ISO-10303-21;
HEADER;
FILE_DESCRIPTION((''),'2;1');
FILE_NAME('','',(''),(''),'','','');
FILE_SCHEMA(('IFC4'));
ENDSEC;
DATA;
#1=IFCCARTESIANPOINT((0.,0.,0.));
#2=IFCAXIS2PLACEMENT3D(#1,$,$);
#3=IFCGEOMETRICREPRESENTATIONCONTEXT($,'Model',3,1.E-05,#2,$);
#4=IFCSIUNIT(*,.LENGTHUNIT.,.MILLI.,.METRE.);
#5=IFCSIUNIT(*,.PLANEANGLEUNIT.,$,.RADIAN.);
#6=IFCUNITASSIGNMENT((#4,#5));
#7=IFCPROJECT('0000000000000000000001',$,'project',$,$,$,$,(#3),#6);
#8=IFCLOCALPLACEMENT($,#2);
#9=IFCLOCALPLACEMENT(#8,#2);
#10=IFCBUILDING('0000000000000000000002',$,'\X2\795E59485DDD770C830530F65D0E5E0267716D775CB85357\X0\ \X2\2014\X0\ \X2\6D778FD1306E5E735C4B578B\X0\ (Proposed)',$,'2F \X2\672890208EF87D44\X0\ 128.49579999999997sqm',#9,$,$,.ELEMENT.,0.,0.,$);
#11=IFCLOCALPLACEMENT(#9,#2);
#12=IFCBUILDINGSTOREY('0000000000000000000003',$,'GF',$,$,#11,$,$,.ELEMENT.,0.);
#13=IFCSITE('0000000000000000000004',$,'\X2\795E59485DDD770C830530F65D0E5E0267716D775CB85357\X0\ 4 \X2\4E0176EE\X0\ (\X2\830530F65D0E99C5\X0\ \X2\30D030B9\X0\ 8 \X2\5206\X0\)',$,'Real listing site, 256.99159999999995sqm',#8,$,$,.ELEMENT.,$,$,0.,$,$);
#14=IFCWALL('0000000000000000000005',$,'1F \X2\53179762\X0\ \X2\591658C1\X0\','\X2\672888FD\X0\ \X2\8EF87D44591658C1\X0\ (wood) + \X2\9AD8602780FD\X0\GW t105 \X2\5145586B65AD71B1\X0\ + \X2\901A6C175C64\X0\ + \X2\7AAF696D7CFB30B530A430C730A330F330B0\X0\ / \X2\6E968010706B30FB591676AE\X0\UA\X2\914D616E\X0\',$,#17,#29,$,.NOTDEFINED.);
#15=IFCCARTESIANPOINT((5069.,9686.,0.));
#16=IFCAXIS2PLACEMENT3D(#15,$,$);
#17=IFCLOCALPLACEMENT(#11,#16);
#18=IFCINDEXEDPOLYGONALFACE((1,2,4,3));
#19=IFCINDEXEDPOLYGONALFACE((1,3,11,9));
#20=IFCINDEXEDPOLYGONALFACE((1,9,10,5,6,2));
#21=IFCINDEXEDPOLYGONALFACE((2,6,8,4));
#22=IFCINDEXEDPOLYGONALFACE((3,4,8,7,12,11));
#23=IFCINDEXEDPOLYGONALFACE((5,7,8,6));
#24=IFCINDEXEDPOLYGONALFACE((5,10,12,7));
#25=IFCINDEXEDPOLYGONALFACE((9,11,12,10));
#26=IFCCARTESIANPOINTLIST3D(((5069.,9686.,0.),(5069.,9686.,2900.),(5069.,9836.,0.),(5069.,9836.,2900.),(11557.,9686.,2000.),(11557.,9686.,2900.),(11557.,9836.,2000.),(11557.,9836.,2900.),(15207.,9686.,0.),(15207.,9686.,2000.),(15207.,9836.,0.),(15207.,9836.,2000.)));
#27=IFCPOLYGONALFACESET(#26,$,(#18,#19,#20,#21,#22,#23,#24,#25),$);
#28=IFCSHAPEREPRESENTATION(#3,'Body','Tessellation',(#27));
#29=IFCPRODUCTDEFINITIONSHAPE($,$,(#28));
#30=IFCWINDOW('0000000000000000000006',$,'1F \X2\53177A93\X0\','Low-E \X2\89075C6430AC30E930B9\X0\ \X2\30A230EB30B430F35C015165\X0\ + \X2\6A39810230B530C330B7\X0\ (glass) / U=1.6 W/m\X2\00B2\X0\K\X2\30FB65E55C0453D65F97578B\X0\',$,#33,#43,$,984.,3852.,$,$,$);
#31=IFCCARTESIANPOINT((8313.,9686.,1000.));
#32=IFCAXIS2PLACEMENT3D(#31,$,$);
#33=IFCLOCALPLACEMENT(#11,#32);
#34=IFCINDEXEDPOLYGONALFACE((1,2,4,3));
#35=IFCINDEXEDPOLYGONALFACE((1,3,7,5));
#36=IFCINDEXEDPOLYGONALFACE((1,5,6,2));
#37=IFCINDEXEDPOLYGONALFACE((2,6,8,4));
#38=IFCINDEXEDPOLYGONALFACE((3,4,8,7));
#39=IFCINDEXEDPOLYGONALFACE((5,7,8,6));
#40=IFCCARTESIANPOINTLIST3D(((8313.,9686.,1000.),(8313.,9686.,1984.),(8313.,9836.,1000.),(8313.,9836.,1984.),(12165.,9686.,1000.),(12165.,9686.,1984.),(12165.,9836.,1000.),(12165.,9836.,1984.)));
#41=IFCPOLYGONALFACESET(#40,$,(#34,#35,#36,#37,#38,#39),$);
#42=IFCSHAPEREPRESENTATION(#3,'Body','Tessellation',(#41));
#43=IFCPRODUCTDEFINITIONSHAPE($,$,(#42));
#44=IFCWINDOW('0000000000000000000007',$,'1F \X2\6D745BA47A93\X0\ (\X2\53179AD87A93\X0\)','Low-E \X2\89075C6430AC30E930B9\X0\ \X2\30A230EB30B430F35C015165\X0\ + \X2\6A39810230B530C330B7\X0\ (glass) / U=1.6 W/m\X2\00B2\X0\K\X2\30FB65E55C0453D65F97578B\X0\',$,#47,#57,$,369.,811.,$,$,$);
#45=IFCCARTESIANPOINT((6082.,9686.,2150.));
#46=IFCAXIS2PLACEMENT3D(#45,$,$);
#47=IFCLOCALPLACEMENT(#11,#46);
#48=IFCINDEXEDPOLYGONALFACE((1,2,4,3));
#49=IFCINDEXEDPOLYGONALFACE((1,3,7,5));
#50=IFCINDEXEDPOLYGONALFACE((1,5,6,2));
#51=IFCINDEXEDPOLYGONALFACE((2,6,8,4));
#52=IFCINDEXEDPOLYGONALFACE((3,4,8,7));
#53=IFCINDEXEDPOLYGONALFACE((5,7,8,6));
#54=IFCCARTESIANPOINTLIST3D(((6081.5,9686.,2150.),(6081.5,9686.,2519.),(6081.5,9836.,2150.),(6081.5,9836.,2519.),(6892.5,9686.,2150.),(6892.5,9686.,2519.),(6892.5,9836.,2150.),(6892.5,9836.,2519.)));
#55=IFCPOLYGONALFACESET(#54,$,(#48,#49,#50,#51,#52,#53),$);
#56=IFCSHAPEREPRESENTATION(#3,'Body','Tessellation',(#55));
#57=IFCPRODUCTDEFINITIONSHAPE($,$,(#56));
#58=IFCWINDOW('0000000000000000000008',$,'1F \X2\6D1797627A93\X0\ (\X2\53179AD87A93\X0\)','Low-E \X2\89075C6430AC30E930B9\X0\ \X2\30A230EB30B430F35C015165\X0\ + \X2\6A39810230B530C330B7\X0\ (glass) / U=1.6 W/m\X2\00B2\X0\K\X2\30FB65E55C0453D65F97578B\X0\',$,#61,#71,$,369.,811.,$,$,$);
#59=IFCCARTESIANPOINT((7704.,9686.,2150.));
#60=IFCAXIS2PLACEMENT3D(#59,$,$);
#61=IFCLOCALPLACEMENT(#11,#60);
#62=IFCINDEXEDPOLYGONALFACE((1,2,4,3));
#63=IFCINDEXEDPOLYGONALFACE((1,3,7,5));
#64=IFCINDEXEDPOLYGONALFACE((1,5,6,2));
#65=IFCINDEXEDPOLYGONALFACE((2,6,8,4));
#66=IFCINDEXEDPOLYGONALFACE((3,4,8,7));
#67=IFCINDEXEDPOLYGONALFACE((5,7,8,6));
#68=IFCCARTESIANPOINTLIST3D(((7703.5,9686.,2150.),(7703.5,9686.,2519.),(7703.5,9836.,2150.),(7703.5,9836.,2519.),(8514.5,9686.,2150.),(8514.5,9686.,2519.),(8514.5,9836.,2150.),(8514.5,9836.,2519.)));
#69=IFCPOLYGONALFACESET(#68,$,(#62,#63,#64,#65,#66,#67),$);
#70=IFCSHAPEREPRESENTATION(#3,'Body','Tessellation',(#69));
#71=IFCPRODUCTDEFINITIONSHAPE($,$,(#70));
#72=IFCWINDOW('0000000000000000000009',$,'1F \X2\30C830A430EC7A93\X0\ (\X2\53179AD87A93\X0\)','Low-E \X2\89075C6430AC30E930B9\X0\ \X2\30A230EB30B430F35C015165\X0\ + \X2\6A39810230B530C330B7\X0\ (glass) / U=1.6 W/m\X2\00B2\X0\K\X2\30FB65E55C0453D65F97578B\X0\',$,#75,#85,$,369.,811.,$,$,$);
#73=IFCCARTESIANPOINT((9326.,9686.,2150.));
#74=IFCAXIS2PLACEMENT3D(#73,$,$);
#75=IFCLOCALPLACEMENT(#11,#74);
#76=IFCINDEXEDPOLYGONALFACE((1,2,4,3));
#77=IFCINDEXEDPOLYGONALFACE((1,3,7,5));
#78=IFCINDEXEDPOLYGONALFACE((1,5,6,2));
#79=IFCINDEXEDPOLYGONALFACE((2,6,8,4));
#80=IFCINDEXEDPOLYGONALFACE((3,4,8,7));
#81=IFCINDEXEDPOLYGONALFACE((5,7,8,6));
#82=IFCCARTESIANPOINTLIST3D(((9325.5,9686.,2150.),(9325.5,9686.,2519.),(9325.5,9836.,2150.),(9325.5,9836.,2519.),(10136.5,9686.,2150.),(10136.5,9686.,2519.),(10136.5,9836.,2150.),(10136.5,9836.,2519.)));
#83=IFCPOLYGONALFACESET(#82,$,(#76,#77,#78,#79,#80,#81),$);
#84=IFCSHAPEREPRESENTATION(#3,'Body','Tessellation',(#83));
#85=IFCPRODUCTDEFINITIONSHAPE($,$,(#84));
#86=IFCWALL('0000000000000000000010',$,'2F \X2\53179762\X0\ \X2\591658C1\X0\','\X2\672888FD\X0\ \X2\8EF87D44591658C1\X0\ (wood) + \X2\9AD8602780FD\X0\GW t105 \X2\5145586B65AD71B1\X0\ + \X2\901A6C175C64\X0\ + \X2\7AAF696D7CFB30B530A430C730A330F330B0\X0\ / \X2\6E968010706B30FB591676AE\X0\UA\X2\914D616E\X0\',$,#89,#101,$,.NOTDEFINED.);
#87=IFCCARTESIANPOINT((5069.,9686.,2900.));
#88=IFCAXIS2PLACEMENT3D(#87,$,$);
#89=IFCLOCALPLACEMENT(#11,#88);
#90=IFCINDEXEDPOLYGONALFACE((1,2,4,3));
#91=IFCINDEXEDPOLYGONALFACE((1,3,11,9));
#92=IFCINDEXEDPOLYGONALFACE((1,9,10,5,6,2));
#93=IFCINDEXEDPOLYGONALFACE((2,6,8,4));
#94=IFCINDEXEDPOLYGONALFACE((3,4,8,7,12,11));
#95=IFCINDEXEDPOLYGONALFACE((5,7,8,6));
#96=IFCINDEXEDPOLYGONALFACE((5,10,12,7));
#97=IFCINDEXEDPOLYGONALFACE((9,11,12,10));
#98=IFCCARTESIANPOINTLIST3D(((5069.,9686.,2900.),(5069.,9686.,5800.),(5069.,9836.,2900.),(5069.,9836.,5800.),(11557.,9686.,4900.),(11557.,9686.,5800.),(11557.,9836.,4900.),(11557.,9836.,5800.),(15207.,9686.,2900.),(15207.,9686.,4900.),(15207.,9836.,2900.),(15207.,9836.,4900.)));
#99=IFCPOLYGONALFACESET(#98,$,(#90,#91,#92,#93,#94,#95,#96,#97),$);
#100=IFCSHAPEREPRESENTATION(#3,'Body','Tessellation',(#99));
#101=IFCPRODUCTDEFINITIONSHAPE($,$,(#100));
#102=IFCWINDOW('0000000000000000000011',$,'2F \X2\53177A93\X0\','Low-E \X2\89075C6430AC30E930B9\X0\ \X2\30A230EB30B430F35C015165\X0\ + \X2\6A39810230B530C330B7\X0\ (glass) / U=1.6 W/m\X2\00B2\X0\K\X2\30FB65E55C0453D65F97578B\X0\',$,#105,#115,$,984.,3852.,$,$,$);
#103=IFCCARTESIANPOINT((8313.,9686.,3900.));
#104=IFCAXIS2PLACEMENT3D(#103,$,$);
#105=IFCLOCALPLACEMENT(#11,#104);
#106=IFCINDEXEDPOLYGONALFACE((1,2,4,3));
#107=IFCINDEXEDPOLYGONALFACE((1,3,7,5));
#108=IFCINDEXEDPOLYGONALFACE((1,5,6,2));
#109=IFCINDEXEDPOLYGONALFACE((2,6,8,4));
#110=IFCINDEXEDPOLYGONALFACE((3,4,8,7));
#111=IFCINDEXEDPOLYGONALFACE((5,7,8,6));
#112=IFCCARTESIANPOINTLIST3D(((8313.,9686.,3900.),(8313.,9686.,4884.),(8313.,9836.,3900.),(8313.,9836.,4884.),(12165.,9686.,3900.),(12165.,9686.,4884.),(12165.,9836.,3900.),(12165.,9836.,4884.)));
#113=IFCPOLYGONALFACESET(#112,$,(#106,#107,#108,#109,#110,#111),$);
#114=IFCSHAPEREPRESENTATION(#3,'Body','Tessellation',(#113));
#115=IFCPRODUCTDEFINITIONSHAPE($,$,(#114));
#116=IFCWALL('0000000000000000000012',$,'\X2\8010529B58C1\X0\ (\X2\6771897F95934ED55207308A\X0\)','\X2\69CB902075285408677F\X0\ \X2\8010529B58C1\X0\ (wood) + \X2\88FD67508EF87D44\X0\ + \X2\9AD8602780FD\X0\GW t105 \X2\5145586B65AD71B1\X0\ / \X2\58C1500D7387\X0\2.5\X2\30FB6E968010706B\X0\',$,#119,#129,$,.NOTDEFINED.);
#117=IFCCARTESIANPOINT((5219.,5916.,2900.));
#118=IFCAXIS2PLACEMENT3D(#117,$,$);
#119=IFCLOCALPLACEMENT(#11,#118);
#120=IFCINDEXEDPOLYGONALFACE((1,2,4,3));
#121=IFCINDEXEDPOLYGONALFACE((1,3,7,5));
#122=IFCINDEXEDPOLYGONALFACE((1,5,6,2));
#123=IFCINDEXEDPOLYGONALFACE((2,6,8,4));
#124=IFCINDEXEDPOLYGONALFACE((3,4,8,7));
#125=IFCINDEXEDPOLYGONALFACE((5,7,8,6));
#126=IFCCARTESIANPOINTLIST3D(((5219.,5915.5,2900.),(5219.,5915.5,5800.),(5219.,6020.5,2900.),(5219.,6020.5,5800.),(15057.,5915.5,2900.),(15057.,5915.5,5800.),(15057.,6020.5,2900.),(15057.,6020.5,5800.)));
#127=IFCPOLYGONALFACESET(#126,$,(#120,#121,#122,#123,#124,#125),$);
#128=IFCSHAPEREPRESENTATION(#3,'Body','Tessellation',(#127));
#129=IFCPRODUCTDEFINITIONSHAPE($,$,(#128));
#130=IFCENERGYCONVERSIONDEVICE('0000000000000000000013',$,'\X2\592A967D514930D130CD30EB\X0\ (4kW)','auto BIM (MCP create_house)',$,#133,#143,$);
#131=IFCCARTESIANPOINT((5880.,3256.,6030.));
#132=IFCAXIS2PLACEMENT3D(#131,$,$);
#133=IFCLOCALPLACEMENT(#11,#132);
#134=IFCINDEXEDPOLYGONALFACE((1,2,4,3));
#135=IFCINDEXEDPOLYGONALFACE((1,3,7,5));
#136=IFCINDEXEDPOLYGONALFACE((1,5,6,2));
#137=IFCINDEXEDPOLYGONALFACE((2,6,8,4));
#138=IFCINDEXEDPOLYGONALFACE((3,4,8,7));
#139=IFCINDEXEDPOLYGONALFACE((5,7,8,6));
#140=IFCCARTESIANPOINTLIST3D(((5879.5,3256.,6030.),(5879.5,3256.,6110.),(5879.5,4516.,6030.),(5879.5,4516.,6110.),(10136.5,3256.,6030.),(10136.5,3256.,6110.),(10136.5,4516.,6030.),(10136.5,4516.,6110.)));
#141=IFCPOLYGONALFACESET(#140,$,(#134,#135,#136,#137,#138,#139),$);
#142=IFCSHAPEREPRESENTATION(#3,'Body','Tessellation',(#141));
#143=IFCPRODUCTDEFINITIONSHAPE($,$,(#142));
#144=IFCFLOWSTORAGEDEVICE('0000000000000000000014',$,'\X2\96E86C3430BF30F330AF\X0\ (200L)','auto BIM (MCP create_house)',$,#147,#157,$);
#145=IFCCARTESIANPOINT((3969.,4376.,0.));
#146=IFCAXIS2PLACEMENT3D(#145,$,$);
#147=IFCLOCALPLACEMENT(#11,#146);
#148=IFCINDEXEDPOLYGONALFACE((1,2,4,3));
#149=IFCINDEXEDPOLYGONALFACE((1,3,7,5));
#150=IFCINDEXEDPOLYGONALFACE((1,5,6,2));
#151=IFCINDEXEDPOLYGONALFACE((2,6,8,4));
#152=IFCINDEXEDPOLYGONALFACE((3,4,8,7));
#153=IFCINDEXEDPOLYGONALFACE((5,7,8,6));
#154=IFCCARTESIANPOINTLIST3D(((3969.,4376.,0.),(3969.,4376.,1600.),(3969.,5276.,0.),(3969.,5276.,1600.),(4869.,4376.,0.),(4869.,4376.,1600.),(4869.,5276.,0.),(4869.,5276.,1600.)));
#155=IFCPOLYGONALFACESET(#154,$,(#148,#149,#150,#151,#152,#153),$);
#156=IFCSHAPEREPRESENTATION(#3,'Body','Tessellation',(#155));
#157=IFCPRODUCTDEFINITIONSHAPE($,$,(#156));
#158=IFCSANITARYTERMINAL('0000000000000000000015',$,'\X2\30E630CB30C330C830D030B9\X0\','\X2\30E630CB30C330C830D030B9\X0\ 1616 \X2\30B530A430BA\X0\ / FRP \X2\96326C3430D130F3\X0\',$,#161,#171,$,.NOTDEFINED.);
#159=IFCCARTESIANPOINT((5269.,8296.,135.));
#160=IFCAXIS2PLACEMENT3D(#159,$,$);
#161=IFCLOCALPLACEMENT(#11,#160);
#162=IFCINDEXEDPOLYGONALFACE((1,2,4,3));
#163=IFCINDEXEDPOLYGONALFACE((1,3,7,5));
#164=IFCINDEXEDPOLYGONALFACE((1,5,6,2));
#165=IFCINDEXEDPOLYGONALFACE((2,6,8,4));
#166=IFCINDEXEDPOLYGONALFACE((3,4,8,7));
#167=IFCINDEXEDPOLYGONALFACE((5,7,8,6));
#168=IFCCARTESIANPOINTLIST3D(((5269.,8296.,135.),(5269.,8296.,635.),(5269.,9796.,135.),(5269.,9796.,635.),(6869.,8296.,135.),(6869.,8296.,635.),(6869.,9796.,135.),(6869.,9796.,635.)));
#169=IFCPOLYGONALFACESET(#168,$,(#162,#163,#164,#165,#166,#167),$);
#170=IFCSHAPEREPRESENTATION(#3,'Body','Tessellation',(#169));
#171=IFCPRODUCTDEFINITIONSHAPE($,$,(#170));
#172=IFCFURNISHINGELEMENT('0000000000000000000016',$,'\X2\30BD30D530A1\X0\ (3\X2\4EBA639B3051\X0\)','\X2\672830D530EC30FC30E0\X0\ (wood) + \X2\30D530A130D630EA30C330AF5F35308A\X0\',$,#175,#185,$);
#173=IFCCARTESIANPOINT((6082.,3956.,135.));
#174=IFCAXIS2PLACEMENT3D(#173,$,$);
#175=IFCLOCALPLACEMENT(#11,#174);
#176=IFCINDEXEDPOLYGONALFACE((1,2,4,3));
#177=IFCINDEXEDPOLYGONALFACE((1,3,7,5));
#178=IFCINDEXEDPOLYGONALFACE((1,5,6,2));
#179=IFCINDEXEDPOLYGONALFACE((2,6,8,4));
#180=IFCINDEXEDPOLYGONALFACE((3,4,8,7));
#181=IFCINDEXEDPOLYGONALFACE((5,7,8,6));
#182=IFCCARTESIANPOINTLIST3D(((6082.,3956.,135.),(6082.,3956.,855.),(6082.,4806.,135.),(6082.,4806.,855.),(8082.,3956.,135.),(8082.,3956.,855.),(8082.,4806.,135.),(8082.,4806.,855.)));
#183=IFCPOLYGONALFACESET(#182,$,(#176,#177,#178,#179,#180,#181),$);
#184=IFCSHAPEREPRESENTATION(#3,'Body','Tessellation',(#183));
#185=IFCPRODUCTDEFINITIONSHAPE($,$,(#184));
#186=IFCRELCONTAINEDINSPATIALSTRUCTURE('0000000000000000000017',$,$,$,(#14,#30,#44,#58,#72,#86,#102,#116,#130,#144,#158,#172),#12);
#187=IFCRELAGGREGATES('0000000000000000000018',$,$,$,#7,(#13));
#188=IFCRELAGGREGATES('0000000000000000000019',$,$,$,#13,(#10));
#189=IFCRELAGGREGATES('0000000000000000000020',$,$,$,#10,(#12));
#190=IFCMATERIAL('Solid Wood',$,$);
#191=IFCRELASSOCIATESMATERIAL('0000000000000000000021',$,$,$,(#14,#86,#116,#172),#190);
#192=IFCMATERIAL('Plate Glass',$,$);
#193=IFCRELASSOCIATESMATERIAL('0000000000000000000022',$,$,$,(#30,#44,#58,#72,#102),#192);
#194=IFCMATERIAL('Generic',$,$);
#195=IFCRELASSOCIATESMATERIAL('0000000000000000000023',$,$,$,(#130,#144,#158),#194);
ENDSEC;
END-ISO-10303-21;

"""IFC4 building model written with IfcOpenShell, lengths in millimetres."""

from ifc_helpers import new_model, si_unit, frame, frame_2d, origin, place, context, project, spatial, rectangle, extrude, material, element, fill, save


model = new_model("IFC4")

# Units and contexts
model_context = context("Model", 3, precision=1e-05, world=origin())
ifc_project = project(units=[si_unit("LENGTHUNIT", "METRE", prefix="MILLI"), si_unit("PLANEANGLEUNIT", "RADIAN")], contexts=[model_context])

# Site, building, storey
site_placement = place(None, origin())
site = spatial("IfcSite", under=ifc_project, at=site_placement, Name="神奈川県茅ヶ崎市東海岸南 4 丁目 (茅ヶ崎駅 バス 8 分)", ObjectType="Real listing site, 256.99159999999995sqm", CompositionType="ELEMENT", RefElevation=0.0)
building_placement = place(site_placement, origin())
building = spatial("IfcBuilding", under=site, at=building_placement, Name="神奈川県茅ヶ崎市東海岸南 — 海近の平屋型 (Proposed)", ObjectType="2F 木造軸組 128.49579999999997sqm", CompositionType="ELEMENT", ElevationOfRefHeight=0.0, ElevationOfTerrain=0.0)
storey_placement = place(building_placement, origin())
storey = spatial("IfcBuildingStorey", under=building, at=storey_placement, Name="GF", CompositionType="ELEMENT", Elevation=0.0)

# Wall, openings, windows
ifc_material_1 = material(Name="Solid Wood")
wall_1_placement = place(storey_placement, frame((5069.0, 9686.0, 0.0)))
wall_1 = element("IfcWall", 1, at=wall_1_placement, inside=storey, material=ifc_material_1, Name="1F 北面 外壁", Description="木製 軸組外壁 (wood) + 高性能GW t105 充填断熱 + 通気層 + 窯業系サイディング / 準耐火・外皮UA配慮", PredefinedType="NOTDEFINED", context=model_context, shape_type="SweptSolid", body=[
    extrude(rectangle(XDim=10138.0, YDim=150.0, at=frame_2d((5069.0, 75.0))), frame((5069.0, 9686.0, 0.0)), (0.0, 0.0, 1.0), 2900.0),
])
opening_1_placement = place(storey_placement, frame((8313.0, 9686.0, 1000.0)))
opening_1 = element("IfcOpeningElement", 2, at=opening_1_placement, cuts=wall_1, PredefinedType="NOTDEFINED", context=model_context, shape_type="SweptSolid", body=[
    extrude(rectangle(XDim=3852.0, YDim=150.0, at=frame_2d((1926.0, 75.0))), frame((8313.0, 9686.0, 1000.0)), (0.0, 0.0, 1.0), 984.0),
])
opening_2_placement = place(storey_placement, frame((6082.0, 9686.0, 2150.0)))
opening_2 = element("IfcOpeningElement", 3, at=opening_2_placement, cuts=wall_1, PredefinedType="NOTDEFINED", context=model_context, shape_type="SweptSolid", body=[
    extrude(rectangle(XDim=811.0, YDim=150.0, at=frame_2d((405.0, 75.0))), frame((6082.0, 9686.0, 2150.0)), (0.0, 0.0, 1.0), 369.0),
])
opening_3_placement = place(storey_placement, frame((7704.0, 9686.0, 2150.0)))
opening_3 = element("IfcOpeningElement", 4, at=opening_3_placement, cuts=wall_1, PredefinedType="NOTDEFINED", context=model_context, shape_type="SweptSolid", body=[
    extrude(rectangle(XDim=811.0, YDim=150.0, at=frame_2d((405.0, 75.0))), frame((7704.0, 9686.0, 2150.0)), (0.0, 0.0, 1.0), 369.0),
])
opening_4_placement = place(storey_placement, frame((9326.0, 9686.0, 2150.0)))
opening_4 = element("IfcOpeningElement", 5, at=opening_4_placement, cuts=wall_1, PredefinedType="NOTDEFINED", context=model_context, shape_type="SweptSolid", body=[
    extrude(rectangle(XDim=811.0, YDim=150.0, at=frame_2d((405.0, 75.0))), frame((9326.0, 9686.0, 2150.0)), (0.0, 0.0, 1.0), 369.0),
])
ifc_material_2 = material(Name="Plate Glass")
window_1_placement = place(storey_placement, frame((8313.0, 9686.0, 1000.0)))
window_1 = element("IfcWindow", 6, at=window_1_placement, inside=storey, material=ifc_material_2, Name="1F 北窓", Description="Low-E 複層ガラス アルゴン封入 + 樹脂サッシ (glass) / U=1.6 W/m²K・日射取得型", OverallHeight=984.0, OverallWidth=3852.0, context=model_context, shape_type="SweptSolid", body=[
    extrude(rectangle(XDim=3852.0, YDim=150.0, at=frame_2d((1926.0, 75.0))), frame((8313.0, 9686.0, 1000.0)), (0.0, 0.0, 1.0), 984.0),
])
fill(opening_1, window_1)
window_2_placement = place(storey_placement, frame((6082.0, 9686.0, 2150.0)))
window_2 = element("IfcWindow", 7, at=window_2_placement, inside=storey, material=ifc_material_2, Name="1F 浴室窓 (北高窓)", Description="Low-E 複層ガラス アルゴン封入 + 樹脂サッシ (glass) / U=1.6 W/m²K・日射取得型", OverallHeight=369.0, OverallWidth=811.0, context=model_context, shape_type="SweptSolid", body=[
    extrude(rectangle(XDim=811.0, YDim=150.0, at=frame_2d((405.0, 75.0))), frame((6082.0, 9686.0, 2150.0)), (0.0, 0.0, 1.0), 369.0),
])
fill(opening_2, window_2)
window_3_placement = place(storey_placement, frame((7704.0, 9686.0, 2150.0)))
window_3 = element("IfcWindow", 8, at=window_3_placement, inside=storey, material=ifc_material_2, Name="1F 洗面窓 (北高窓)", Description="Low-E 複層ガラス アルゴン封入 + 樹脂サッシ (glass) / U=1.6 W/m²K・日射取得型", OverallHeight=369.0, OverallWidth=811.0, context=model_context, shape_type="SweptSolid", body=[
    extrude(rectangle(XDim=811.0, YDim=150.0, at=frame_2d((405.0, 75.0))), frame((7704.0, 9686.0, 2150.0)), (0.0, 0.0, 1.0), 369.0),
])
fill(opening_3, window_3)
window_4_placement = place(storey_placement, frame((9326.0, 9686.0, 2150.0)))
window_4 = element("IfcWindow", 9, at=window_4_placement, inside=storey, material=ifc_material_2, Name="1F トイレ窓 (北高窓)", Description="Low-E 複層ガラス アルゴン封入 + 樹脂サッシ (glass) / U=1.6 W/m²K・日射取得型", OverallHeight=369.0, OverallWidth=811.0, context=model_context, shape_type="SweptSolid", body=[
    extrude(rectangle(XDim=811.0, YDim=150.0, at=frame_2d((405.0, 75.0))), frame((9326.0, 9686.0, 2150.0)), (0.0, 0.0, 1.0), 369.0),
])
fill(opening_4, window_4)

# Wall, opening, window
wall_2_placement = place(storey_placement, frame((5069.0, 9686.0, 2900.0)))
wall_2 = element("IfcWall", 10, at=wall_2_placement, inside=storey, material=ifc_material_1, Name="2F 北面 外壁", Description="木製 軸組外壁 (wood) + 高性能GW t105 充填断熱 + 通気層 + 窯業系サイディング / 準耐火・外皮UA配慮", PredefinedType="NOTDEFINED", context=model_context, shape_type="SweptSolid", body=[
    extrude(rectangle(XDim=10138.0, YDim=150.0, at=frame_2d((5069.0, 75.0))), frame((5069.0, 9686.0, 2900.0)), (0.0, 0.0, 1.0), 2900.0),
])
opening_5_placement = place(storey_placement, frame((8313.0, 9686.0, 3900.0)))
opening_5 = element("IfcOpeningElement", 11, at=opening_5_placement, cuts=wall_2, PredefinedType="NOTDEFINED", context=model_context, shape_type="SweptSolid", body=[
    extrude(rectangle(XDim=3852.0, YDim=150.0, at=frame_2d((1926.0, 75.0))), frame((8313.0, 9686.0, 3900.0)), (0.0, 0.0, 1.0), 984.0),
])
window_5_placement = place(storey_placement, frame((8313.0, 9686.0, 3900.0)))
window_5 = element("IfcWindow", 12, at=window_5_placement, inside=storey, material=ifc_material_2, Name="2F 北窓", Description="Low-E 複層ガラス アルゴン封入 + 樹脂サッシ (glass) / U=1.6 W/m²K・日射取得型", OverallHeight=984.0, OverallWidth=3852.0, context=model_context, shape_type="SweptSolid", body=[
    extrude(rectangle(XDim=3852.0, YDim=150.0, at=frame_2d((1926.0, 75.0))), frame((8313.0, 9686.0, 3900.0)), (0.0, 0.0, 1.0), 984.0),
])
fill(opening_5, window_5)

# Wall
wall_3_placement = place(storey_placement, frame((5219.0, 5916.0, 2900.0)))
element("IfcWall", 13, at=wall_3_placement, inside=storey, material=ifc_material_1, Name="耐力壁 (東西間仕切り)", Description="構造用合板 耐力壁 (wood) + 製材軸組 + 高性能GW t105 充填断熱 / 壁倍率2.5・準耐火", PredefinedType="NOTDEFINED", context=model_context, shape_type="SweptSolid", body=[
    extrude(rectangle(XDim=9838.0, YDim=105.0, at=frame_2d((4919.0, 52.0))), frame((5219.0, 5916.0, 2900.0)), (0.0, 0.0, 1.0), 2900.0),
])

# Energy conversion device
ifc_material_3 = material(Name="Generic")
energy_conversion_device_placement = place(storey_placement, frame((5880.0, 3256.0, 6030.0)))
element("IfcEnergyConversionDevice", 14, at=energy_conversion_device_placement, inside=storey, material=ifc_material_3, Name="太陽光パネル (4kW)", Description="auto BIM (MCP create_house)", context=model_context, shape_type="SweptSolid", body=[
    extrude(rectangle(XDim=4257.0, YDim=1260.0, at=frame_2d((2128.0, 630.0))), frame((5880.0, 3256.0, 6030.0)), (0.0, 0.0, 1.0), 80.0),
])

# Flow storage device
flow_storage_device_placement = place(storey_placement, frame((3969.0, 4376.0, 0.0)))
element("IfcFlowStorageDevice", 15, at=flow_storage_device_placement, inside=storey, material=ifc_material_3, Name="雨水タンク (200L)", Description="auto BIM (MCP create_house)", context=model_context, shape_type="SweptSolid", body=[
    extrude(rectangle(XDim=900.0, YDim=900.0, at=frame_2d((450.0, 450.0))), frame((3969.0, 4376.0, 0.0)), (0.0, 0.0, 1.0), 1600.0),
])

# Sanitary terminal
sanitary_terminal_placement = place(storey_placement, frame((5269.0, 8296.0, 135.0)))
element("IfcSanitaryTerminal", 16, at=sanitary_terminal_placement, inside=storey, material=ifc_material_3, Name="ユニットバス", Description="ユニットバス 1616 サイズ / FRP 防水パン", PredefinedType="NOTDEFINED", context=model_context, shape_type="SweptSolid", body=[
    extrude(rectangle(XDim=1600.0, YDim=1500.0, at=frame_2d((800.0, 750.0))), frame((5269.0, 8296.0, 135.0)), (0.0, 0.0, 1.0), 500.0),
])

# Furnishing element
furnishing_1_placement = place(storey_placement, frame((6082.0, 3956.0, 135.0)))
element("IfcFurnishingElement", 17, at=furnishing_1_placement, inside=storey, material=ifc_material_1, Name="ソファ (3人掛け)", Description="木フレーム (wood) + ファブリック張り", context=model_context, shape_type="SweptSolid", body=[
    extrude(rectangle(XDim=2000.0, YDim=850.0, at=frame_2d((1000.0, 425.0))), frame((6082.0, 3956.0, 135.0)), (0.0, 0.0, 1.0), 720.0),
])

save(model, "model.ifc")
